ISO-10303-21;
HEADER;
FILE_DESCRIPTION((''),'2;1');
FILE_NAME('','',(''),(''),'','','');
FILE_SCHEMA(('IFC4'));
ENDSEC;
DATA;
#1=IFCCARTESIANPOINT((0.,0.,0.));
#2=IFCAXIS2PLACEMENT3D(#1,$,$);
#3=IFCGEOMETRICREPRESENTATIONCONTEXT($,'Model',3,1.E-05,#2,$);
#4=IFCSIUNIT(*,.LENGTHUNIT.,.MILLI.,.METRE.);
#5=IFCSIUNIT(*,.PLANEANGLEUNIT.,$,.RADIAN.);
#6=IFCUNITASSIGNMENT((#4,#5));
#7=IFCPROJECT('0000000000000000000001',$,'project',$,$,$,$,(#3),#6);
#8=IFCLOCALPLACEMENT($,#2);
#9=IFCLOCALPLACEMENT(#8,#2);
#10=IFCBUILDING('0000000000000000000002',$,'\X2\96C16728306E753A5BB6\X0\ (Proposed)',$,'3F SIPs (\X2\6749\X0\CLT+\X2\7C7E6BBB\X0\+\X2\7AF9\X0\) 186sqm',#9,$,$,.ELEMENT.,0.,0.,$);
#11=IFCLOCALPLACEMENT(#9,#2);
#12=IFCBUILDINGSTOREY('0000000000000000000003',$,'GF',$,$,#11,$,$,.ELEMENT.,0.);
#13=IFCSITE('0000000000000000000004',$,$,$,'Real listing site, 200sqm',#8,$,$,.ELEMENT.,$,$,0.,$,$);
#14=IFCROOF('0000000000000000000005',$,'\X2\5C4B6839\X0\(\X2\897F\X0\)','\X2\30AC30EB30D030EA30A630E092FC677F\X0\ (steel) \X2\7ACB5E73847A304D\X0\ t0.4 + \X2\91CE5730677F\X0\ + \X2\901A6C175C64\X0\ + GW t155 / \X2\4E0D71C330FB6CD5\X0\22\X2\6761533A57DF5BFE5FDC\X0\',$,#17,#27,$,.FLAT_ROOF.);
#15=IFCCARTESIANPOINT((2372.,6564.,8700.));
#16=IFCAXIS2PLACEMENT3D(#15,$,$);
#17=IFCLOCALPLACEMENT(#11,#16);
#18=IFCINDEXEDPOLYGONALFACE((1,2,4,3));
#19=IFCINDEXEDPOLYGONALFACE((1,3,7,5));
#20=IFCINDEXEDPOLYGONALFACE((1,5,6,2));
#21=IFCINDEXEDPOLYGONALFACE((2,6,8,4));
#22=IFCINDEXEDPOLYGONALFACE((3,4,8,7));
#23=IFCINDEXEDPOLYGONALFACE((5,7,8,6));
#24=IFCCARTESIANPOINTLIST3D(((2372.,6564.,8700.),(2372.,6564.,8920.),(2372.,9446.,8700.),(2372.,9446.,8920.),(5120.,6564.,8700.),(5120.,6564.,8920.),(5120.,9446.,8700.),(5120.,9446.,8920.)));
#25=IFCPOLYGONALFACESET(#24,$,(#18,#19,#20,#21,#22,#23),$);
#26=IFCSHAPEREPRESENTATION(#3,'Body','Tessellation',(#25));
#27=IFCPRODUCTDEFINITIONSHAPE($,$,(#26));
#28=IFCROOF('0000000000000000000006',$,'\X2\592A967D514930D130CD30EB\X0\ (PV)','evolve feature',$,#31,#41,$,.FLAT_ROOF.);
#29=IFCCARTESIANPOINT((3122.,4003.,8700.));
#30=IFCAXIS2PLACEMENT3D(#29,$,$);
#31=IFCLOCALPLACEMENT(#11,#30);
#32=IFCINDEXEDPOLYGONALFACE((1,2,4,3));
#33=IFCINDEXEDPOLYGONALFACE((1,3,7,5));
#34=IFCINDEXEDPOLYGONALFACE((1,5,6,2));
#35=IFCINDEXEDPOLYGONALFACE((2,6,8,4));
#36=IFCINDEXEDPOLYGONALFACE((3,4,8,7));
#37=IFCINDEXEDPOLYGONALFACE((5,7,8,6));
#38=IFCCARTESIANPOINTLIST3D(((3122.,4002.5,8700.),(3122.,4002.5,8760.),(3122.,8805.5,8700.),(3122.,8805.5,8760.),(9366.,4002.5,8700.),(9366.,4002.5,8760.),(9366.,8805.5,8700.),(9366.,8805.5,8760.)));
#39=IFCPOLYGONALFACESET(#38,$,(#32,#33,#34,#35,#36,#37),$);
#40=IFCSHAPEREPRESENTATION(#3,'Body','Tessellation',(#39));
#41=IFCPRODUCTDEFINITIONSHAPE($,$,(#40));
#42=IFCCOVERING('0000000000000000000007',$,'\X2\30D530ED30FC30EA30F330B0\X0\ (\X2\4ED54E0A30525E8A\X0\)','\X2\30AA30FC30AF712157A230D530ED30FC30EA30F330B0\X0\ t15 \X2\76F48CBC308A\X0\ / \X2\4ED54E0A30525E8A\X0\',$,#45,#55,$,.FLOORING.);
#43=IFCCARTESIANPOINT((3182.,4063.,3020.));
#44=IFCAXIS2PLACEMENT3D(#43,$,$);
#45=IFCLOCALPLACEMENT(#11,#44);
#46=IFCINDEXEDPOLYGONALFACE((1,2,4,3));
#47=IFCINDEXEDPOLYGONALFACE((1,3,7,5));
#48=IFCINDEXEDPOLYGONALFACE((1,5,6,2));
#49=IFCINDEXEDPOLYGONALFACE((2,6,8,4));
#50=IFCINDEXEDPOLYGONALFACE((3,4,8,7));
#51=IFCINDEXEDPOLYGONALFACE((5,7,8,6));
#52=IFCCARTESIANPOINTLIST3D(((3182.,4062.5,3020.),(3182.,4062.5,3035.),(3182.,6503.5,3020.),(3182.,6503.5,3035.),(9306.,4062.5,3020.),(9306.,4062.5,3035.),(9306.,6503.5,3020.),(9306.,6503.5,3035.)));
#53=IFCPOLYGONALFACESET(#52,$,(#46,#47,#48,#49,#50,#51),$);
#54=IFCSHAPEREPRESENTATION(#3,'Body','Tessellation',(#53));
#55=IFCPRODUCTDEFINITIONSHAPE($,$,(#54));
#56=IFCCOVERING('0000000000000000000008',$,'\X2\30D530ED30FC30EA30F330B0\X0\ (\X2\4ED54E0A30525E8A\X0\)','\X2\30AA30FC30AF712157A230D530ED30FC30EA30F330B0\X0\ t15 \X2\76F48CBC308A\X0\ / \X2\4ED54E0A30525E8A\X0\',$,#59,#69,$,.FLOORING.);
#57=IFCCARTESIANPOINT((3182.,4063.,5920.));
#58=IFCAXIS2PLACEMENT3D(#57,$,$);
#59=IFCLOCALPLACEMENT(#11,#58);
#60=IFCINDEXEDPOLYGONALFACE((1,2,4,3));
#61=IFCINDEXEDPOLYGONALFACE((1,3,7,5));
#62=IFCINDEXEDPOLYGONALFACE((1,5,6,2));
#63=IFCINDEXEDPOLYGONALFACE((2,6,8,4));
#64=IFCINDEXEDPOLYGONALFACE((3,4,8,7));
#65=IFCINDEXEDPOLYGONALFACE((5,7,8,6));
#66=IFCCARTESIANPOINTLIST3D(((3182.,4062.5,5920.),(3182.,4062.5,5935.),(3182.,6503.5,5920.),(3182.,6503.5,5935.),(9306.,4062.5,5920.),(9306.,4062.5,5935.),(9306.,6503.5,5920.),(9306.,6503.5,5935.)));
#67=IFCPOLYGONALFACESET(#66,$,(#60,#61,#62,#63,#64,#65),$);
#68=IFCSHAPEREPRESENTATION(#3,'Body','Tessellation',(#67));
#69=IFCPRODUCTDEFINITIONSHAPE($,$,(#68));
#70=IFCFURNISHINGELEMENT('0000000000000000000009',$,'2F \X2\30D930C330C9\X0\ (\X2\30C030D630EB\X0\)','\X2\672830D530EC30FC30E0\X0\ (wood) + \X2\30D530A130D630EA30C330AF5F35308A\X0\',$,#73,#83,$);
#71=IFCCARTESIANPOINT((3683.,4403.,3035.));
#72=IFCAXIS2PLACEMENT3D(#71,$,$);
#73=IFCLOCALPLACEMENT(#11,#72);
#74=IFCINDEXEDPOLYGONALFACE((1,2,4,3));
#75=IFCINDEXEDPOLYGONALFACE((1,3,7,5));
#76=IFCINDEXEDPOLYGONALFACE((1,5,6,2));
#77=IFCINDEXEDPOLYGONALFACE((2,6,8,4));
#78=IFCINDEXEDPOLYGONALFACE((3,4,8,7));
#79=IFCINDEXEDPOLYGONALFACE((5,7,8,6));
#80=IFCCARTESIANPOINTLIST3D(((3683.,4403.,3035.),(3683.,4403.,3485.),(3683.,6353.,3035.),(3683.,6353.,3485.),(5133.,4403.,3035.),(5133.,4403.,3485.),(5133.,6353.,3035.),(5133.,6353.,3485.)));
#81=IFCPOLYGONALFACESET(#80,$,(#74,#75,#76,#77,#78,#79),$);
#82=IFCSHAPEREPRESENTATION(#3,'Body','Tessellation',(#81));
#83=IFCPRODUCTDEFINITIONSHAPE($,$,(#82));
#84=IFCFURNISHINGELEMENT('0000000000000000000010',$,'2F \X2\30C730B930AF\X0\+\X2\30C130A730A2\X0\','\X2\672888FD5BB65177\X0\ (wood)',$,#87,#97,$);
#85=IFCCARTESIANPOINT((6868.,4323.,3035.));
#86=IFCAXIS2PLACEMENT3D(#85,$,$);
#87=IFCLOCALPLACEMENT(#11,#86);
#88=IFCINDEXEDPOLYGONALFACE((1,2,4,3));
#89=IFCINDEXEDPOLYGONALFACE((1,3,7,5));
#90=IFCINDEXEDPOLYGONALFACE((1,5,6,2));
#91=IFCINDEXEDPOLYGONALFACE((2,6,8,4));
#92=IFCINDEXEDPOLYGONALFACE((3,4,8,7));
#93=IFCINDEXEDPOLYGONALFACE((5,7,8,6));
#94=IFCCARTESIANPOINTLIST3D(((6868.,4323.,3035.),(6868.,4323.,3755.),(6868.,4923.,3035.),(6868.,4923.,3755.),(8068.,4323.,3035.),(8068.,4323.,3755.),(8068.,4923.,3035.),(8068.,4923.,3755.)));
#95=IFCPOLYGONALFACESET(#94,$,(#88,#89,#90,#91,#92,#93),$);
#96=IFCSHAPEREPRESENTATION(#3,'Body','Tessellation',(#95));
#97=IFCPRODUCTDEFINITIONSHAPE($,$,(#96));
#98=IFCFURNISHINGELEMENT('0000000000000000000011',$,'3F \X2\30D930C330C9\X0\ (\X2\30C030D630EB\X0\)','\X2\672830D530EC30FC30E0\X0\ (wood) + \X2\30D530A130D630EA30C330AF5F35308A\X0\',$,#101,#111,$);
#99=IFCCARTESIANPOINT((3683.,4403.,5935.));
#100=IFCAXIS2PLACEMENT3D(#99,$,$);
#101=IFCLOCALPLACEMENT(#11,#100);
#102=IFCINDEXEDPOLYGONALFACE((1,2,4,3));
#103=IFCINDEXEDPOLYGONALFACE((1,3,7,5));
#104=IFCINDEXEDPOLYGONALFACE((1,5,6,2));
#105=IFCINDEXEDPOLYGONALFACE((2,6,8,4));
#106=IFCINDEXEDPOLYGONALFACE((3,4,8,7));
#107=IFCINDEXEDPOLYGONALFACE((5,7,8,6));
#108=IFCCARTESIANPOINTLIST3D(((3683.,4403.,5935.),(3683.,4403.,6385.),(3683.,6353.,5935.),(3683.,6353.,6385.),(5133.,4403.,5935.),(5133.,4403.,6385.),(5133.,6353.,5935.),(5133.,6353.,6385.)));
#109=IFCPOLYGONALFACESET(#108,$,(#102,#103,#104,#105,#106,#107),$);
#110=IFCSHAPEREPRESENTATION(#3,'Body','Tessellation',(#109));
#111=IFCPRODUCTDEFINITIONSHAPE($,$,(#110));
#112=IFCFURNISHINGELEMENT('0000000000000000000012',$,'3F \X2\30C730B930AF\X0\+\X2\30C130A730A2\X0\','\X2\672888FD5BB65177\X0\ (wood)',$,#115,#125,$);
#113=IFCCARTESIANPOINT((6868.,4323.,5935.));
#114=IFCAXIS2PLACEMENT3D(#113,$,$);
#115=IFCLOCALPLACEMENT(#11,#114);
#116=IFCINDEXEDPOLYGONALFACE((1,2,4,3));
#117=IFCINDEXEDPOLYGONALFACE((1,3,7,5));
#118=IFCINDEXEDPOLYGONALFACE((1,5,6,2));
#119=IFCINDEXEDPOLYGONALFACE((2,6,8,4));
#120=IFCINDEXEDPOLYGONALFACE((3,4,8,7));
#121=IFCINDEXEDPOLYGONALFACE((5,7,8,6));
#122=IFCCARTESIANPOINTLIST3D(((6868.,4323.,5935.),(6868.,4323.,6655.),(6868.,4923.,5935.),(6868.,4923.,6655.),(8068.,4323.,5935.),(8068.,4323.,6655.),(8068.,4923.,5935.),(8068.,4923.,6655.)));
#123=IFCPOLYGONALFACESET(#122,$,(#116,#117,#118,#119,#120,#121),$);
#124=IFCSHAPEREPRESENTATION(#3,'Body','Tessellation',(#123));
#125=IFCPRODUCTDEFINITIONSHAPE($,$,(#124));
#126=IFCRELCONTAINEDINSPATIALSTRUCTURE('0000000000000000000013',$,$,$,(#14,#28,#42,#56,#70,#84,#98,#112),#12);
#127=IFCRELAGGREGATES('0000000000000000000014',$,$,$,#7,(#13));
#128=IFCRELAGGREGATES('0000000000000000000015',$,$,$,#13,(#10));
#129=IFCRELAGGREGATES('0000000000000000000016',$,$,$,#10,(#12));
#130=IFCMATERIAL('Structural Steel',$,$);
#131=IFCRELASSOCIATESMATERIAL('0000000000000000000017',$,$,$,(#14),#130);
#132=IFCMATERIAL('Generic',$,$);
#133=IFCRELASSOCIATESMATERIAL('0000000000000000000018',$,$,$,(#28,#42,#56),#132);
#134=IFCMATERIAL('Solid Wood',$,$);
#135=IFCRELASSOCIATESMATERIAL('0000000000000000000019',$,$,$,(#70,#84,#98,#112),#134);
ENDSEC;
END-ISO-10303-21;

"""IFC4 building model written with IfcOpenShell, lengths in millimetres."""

from ifc_helpers import new_model, si_unit, frame, frame_2d, origin, place, context, project, spatial, rectangle, extrude, material, element, save


model = new_model("IFC4")

# Units and contexts
model_context = context("Model", 3, precision=1e-05, world=origin())
ifc_project = project(units=[si_unit("LENGTHUNIT", "METRE", prefix="MILLI"), si_unit("PLANEANGLEUNIT", "RADIAN")], contexts=[model_context])

# Site, building, storey
site_placement = place(None, origin())
site = spatial("IfcSite", under=ifc_project, at=site_placement, ObjectType="Real listing site, 200sqm", CompositionType="ELEMENT", RefElevation=0.0)
building_placement = place(site_placement, origin())
building = spatial("IfcBuilding", under=site, at=building_placement, Name="雁木の町家 (Proposed)", ObjectType="3F SIPs (杉CLT+籾殻+竹) 186sqm", CompositionType="ELEMENT", ElevationOfRefHeight=0.0, ElevationOfTerrain=0.0)
storey_placement = place(building_placement, origin())
storey = spatial("IfcBuildingStorey", under=building, at=storey_placement, Name="GF", CompositionType="ELEMENT", Elevation=0.0)

# Shared definitions
ifc_material_1 = material(Name="Solid Wood")

# Roofs
ifc_material_2 = material(Name="Structural Steel")
roof_1_placement = place(storey_placement, frame((2372.0, 6564.0, 8700.0)))
element("IfcRoof", 1, at=roof_1_placement, inside=storey, material=ifc_material_2, Name="屋根(西)", Description="ガルバリウム鋼板 (steel) 立平葺き t0.4 + 野地板 + 通気層 + GW t155 / 不燃・法22条区域対応", PredefinedType="FLAT_ROOF", context=model_context, shape_type="SweptSolid", body=[
    extrude(rectangle(XDim=2748.0, YDim=2882.0, at=frame_2d((1374.0, 1441.0))), frame((2372.0, 6564.0, 8700.0)), (0.0, 0.0, 1.0), 220.0),
])
ifc_material_3 = material(Name="Generic")
roof_2_placement = place(storey_placement, frame((3122.0, 4003.0, 8700.0)))
element("IfcRoof", 2, at=roof_2_placement, inside=storey, material=ifc_material_3, Name="太陽光パネル (PV)", Description="evolve feature", PredefinedType="FLAT_ROOF", context=model_context, shape_type="SweptSolid", body=[
    extrude(rectangle(XDim=6244.0, YDim=4803.0, at=frame_2d((3122.0, 2401.0))), frame((3122.0, 4003.0, 8700.0)), (0.0, 0.0, 1.0), 60.0),
])

# Coverings
covering_1_placement = place(storey_placement, frame((3182.0, 4063.0, 3020.0)))
element("IfcCovering", 3, at=covering_1_placement, inside=storey, material=ifc_material_3, Name="フローリング (仕上げ床)", Description="オーク無垢フローリング t15 直貼り / 仕上げ床", PredefinedType="FLOORING", context=model_context, shape_type="SweptSolid", body=[
    extrude(rectangle(XDim=6124.0, YDim=2441.0, at=frame_2d((3062.0, 1220.0))), frame((3182.0, 4063.0, 3020.0)), (0.0, 0.0, 1.0), 15.0),
])
covering_2_placement = place(storey_placement, frame((3182.0, 4063.0, 5920.0)))
element("IfcCovering", 4, at=covering_2_placement, inside=storey, material=ifc_material_3, Name="フローリング (仕上げ床)", Description="オーク無垢フローリング t15 直貼り / 仕上げ床", PredefinedType="FLOORING", context=model_context, shape_type="SweptSolid", body=[
    extrude(rectangle(XDim=6124.0, YDim=2441.0, at=frame_2d((3062.0, 1220.0))), frame((3182.0, 4063.0, 5920.0)), (0.0, 0.0, 1.0), 15.0),
])

# Furnishing elements
furnishing_1_placement = place(storey_placement, frame((3683.0, 4403.0, 3035.0)))
element("IfcFurnishingElement", 5, at=furnishing_1_placement, inside=storey, material=ifc_material_1, Name="2F ベッド (ダブル)", Description="木フレーム (wood) + ファブリック張り", context=model_context, shape_type="SweptSolid", body=[
    extrude(rectangle(XDim=1450.0, YDim=1950.0, at=frame_2d((725.0, 975.0))), frame((3683.0, 4403.0, 3035.0)), (0.0, 0.0, 1.0), 450.0),
])
furnishing_2_placement = place(storey_placement, frame((6868.0, 4323.0, 3035.0)))
element("IfcFurnishingElement", 6, at=furnishing_2_placement, inside=storey, material=ifc_material_1, Name="2F デスク+チェア", Description="木製家具 (wood)", context=model_context, shape_type="SweptSolid", body=[
    extrude(rectangle(XDim=1200.0, YDim=600.0, at=frame_2d((600.0, 300.0))), frame((6868.0, 4323.0, 3035.0)), (0.0, 0.0, 1.0), 720.0),
])
furnishing_3_placement = place(storey_placement, frame((3683.0, 4403.0, 5935.0)))
element("IfcFurnishingElement", 7, at=furnishing_3_placement, inside=storey, material=ifc_material_1, Name="3F ベッド (ダブル)", Description="木フレーム (wood) + ファブリック張り", context=model_context, shape_type="SweptSolid", body=[
    extrude(rectangle(XDim=1450.0, YDim=1950.0, at=frame_2d((725.0, 975.0))), frame((3683.0, 4403.0, 5935.0)), (0.0, 0.0, 1.0), 450.0),
])
furnishing_4_placement = place(storey_placement, frame((6868.0, 4323.0, 5935.0)))
element("IfcFurnishingElement", 8, at=furnishing_4_placement, inside=storey, material=ifc_material_1, Name="3F デスク+チェア", Description="木製家具 (wood)", context=model_context, shape_type="SweptSolid", body=[
    extrude(rectangle(XDim=1200.0, YDim=600.0, at=frame_2d((600.0, 300.0))), frame((6868.0, 4323.0, 5935.0)), (0.0, 0.0, 1.0), 720.0),
])

save(model, "model.ifc")
